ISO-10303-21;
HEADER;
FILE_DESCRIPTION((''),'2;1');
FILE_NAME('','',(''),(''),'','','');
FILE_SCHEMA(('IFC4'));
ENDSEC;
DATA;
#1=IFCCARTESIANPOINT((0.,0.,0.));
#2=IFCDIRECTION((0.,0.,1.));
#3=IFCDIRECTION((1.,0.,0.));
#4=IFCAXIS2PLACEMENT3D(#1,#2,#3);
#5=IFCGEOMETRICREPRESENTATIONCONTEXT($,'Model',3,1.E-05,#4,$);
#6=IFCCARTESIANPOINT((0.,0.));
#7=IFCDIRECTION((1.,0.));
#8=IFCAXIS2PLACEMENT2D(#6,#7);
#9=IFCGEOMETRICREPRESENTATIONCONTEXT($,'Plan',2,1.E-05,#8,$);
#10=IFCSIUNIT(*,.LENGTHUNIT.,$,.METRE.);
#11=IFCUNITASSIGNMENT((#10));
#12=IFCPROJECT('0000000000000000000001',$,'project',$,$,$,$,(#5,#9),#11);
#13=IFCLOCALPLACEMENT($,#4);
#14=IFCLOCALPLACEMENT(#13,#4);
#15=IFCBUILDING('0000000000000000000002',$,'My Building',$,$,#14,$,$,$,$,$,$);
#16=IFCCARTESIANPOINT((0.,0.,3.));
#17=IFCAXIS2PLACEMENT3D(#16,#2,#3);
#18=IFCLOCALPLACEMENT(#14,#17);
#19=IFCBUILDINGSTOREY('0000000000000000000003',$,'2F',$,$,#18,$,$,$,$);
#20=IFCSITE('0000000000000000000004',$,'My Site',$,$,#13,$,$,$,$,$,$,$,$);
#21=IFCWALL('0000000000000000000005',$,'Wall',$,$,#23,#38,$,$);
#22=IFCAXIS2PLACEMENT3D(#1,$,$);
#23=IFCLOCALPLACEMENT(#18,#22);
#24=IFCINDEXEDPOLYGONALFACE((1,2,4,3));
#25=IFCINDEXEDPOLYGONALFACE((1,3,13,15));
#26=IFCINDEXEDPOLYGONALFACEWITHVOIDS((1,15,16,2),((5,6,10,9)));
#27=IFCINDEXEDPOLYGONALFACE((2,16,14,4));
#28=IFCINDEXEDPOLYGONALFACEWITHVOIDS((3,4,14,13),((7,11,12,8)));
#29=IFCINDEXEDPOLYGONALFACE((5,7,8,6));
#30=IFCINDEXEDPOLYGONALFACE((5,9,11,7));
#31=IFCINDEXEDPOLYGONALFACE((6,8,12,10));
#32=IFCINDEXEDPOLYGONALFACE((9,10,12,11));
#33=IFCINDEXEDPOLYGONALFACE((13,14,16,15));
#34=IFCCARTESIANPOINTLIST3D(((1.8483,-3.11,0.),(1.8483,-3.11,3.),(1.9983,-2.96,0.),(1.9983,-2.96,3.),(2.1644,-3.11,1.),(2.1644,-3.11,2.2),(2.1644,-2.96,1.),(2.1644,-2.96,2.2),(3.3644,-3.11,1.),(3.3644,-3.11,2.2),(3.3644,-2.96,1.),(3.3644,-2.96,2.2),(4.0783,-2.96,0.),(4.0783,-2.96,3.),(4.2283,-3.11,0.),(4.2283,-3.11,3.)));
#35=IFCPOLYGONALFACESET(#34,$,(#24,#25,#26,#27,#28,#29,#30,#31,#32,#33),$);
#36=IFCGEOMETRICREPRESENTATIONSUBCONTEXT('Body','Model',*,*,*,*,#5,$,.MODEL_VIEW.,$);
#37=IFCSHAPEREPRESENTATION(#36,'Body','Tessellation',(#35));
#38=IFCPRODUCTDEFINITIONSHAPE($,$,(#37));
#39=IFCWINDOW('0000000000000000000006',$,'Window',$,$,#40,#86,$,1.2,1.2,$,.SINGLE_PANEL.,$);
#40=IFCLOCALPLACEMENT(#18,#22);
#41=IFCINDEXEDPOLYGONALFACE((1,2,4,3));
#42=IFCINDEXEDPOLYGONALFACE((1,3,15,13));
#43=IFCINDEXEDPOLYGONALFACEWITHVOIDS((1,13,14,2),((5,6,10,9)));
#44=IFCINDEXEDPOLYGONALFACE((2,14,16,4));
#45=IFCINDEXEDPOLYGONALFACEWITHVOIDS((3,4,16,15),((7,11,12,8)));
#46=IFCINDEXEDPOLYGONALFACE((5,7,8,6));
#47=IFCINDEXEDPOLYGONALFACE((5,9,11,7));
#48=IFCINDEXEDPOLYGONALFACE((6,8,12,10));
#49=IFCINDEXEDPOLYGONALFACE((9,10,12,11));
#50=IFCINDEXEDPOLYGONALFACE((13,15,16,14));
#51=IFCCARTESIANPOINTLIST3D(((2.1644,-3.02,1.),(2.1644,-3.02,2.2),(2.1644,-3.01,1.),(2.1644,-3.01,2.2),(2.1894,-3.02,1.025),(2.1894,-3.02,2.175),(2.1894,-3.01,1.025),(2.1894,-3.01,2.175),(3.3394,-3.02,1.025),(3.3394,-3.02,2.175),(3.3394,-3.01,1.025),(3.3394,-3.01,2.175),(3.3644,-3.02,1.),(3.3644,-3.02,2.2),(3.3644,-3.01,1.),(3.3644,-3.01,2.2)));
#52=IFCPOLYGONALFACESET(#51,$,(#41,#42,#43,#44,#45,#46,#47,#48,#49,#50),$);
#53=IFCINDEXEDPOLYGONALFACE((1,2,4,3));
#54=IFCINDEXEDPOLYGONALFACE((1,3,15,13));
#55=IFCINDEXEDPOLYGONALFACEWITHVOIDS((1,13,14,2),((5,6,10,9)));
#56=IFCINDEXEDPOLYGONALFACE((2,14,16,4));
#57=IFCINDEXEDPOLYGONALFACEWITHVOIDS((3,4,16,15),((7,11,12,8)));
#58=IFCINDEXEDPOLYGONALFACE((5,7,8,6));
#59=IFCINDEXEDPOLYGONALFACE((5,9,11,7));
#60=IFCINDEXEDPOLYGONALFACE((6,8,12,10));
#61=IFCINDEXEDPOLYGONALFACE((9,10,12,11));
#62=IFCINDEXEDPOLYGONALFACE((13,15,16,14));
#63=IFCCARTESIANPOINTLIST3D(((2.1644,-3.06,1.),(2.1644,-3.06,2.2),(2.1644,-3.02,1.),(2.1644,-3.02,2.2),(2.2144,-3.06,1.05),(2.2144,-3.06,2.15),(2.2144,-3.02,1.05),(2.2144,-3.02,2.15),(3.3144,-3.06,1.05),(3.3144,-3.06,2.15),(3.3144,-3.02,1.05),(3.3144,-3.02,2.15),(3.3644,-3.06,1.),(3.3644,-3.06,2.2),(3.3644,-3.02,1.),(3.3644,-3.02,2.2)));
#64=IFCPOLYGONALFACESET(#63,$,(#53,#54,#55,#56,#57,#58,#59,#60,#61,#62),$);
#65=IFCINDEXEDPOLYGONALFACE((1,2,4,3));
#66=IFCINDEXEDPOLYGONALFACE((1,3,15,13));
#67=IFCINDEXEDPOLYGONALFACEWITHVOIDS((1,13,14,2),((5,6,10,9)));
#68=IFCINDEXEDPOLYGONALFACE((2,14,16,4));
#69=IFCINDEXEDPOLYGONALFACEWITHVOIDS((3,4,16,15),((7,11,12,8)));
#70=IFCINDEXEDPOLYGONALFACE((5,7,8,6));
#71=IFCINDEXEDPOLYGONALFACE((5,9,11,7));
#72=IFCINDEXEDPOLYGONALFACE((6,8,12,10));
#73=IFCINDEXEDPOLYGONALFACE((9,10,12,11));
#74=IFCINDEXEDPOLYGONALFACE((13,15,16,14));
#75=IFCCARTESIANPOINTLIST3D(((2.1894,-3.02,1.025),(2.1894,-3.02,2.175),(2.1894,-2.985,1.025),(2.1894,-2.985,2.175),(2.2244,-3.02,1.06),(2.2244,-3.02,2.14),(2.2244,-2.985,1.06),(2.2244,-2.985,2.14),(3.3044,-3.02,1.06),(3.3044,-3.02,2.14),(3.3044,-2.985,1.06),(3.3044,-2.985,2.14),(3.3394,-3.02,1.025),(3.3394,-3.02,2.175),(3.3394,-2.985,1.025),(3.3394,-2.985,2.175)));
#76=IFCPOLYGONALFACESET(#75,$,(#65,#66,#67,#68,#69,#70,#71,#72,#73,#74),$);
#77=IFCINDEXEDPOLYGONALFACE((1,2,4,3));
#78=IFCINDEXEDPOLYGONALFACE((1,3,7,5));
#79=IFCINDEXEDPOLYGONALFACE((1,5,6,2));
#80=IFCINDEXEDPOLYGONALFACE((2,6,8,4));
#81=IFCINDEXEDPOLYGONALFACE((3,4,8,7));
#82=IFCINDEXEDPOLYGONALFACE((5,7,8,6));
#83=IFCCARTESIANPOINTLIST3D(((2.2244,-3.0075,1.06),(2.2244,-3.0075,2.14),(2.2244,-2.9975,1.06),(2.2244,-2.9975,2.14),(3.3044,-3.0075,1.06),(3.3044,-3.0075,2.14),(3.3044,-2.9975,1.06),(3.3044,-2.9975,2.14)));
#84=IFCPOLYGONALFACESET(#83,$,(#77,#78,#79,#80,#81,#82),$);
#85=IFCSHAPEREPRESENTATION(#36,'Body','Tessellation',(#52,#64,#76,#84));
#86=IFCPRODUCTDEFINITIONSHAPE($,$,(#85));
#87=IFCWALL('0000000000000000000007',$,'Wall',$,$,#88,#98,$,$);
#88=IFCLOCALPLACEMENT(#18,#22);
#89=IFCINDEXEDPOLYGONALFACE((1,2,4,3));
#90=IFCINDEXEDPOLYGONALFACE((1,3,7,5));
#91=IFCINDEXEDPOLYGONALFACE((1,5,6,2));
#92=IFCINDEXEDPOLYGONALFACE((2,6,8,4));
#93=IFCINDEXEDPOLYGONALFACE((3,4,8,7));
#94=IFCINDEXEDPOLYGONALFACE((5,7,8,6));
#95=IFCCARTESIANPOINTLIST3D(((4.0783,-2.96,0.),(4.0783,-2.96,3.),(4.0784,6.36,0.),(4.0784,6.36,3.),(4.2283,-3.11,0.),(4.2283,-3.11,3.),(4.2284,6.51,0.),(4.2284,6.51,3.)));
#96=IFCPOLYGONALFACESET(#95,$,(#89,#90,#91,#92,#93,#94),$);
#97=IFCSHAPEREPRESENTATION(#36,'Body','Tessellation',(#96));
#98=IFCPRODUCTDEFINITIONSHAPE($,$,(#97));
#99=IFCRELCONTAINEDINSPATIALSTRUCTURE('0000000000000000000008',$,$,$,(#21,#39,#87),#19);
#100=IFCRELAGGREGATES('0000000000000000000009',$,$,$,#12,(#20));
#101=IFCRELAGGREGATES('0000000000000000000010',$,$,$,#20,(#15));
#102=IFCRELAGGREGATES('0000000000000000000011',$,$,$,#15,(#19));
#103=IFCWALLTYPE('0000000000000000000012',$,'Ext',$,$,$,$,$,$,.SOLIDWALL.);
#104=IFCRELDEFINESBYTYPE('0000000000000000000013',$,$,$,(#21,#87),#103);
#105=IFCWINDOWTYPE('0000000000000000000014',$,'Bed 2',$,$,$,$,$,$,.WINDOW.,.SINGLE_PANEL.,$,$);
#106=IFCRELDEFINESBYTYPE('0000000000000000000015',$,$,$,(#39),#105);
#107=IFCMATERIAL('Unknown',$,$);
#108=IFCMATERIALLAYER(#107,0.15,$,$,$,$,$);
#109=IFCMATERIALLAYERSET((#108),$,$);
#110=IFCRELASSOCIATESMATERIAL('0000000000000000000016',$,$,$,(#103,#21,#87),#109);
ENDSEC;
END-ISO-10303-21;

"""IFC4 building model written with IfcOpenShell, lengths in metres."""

from ifc_helpers import new_model, entity, si_unit, frame, origin_with_axes, origin_2d_with_axis, place, context, subcontext, project, spatial, line, indexed_curve, outline, extrude, shape, source, transform, mapped, material, layer, layer_set, layer_usage, type_object, type_shapes, element, fill, save


model = new_model("IFC4")

# Units and contexts
model_context = context("Model", 3, precision=1e-05, world=origin_with_axes())
plan_context = context("Plan", 2, precision=1e-05, world=origin_2d_with_axis())
body_context_1 = subcontext(model_context, "Body", "Model", "MODEL_VIEW")
body_context_2 = subcontext(plan_context, "Body", "Plan", "PLAN_VIEW")
ifc_project = project(units=[si_unit("LENGTHUNIT", "METRE")], contexts=[model_context, plan_context])

# Site, building, storey
site_placement = place(None, origin_with_axes())
site = spatial("IfcSite", under=ifc_project, at=site_placement, Name="My Site")
building_placement = place(site_placement, origin_with_axes())
building = spatial("IfcBuilding", under=site, at=building_placement, Name="My Building")
storey_placement = place(building_placement, frame((0.0, 0.0, 3.0), z_axis=(0.0, 0.0, 1.0), x_axis=(1.0, 0.0, 0.0)))
storey = spatial("IfcBuildingStorey", under=building, at=storey_placement, Name="2F")

# Shared definitions
ifc_material = material(Name="Unknown")

# Shared definitions
ifc_layer_1 = layer(ifc_material, 0.15)
ifc_layer_set_1 = layer_set([ifc_layer_1])
wall_type_1 = type_object("IfcWallType", Name="Ext", PredefinedType="SOLIDWALL", material=ifc_layer_set_1)

# Wall, opening, window
ifc_layer_usage_1 = layer_usage(ifc_layer_set_1, "AXIS2", "POSITIVE", 0.0)
wall_1_placement = place(storey_placement, frame((1.8483, -3.11, 0.0), z_axis=(0.0, 0.0, 1.0), x_axis=(1.0, 0.0, 0.0)))
wall_1 = element("IfcWall", 1, at=wall_1_placement, inside=storey, type_object=wall_type_1, material=ifc_layer_usage_1, Name="Wall", context=body_context_1, shape_type="SweptSolid", body=[
    extrude(outline(indexed_curve([(0.0, 0.0), (0.15, 0.15), (2.23, 0.15), (2.38, 0.0)], segments=[line(1, 2, 3, 4, 1)])), origin_with_axes(), (0.0, 0.0, 1.0), 3.0),
])
shared_shape_1 = source(origin_with_axes(), body_context_1, "Body", "SweptSolid", [
    extrude(outline(indexed_curve([(0.0, 0.0), (1.2, 0.0), (1.2, 1.2), (0.0, 1.2)], segments=[line(1, 2, 3, 4, 1)])), frame((0.0, -0.6, 0.0), z_axis=(0.0, -1.0, 0.0), x_axis=(1.0, 0.0, 0.0)), (0.0, 0.0, -1.0), 1.2),
])
opening_1_placement = place(wall_1_placement, frame((0.316, 0.0, 1.0), z_axis=(0.0, 0.0, 1.0), x_axis=(1.0, 0.0, 0.0)))
opening_1 = element("IfcOpeningElement", 2, at=opening_1_placement, cuts=wall_1, PredefinedType="OPENING", context=body_context_1, shape_type="MappedRepresentation", body=[
    mapped(shared_shape_1, transform((0.0, 0.0, 0.0), x_axis=(1.0, 0.0, 0.0), y_axis=(0.0, 1.0, 0.0), z_axis=(0.0, 0.0, 1.0), scale=1.0)),
])
window_type = type_object("IfcWindowType", Name="Bed 2", PartitioningType="SINGLE_PANEL", PredefinedType="WINDOW")
shared_shape_2 = source(origin_with_axes(), body_context_1, "Body", "SweptSolid", [
    extrude(outline(indexed_curve([(0.0, 1.2), (1.2, 1.2), (1.2, 0.0), (0.0, 0.0), (0.0, 1.2)]), holes=[indexed_curve([(0.025, 1.175), (1.175, 1.175), (1.175, 0.025), (0.025, 0.025), (0.025, 1.175)])]), frame((0.0, 0.09, 0.0), z_axis=(0.0, -1.0, 0.0), x_axis=(1.0, 0.0, 0.0)), (0.0, 0.0, -1.0), 0.01),
    extrude(outline(indexed_curve([(0.0, 0.0), (1.2, 0.0), (1.2, 1.2), (0.0, 1.2)], segments=[line(1, 2, 3, 4, 1)]), holes=[indexed_curve([(0.05, 0.05), (1.15, 0.05), (1.15, 1.15), (0.05, 1.15)], segments=[line(1, 2, 3, 4, 1)])]), frame((0.0, 0.05, 0.0), z_axis=(0.0, -1.0, 0.0), x_axis=(1.0, 0.0, 0.0)), (0.0, 0.0, -1.0), 0.04),
    extrude(outline(indexed_curve([(0.0, 0.0), (1.15, 0.0), (1.15, 1.15), (0.0, 1.15)], segments=[line(1, 2, 3, 4, 1)]), holes=[indexed_curve([(0.035, 0.035), (1.115, 0.035), (1.115, 1.115), (0.035, 1.115)], segments=[line(1, 2, 3, 4, 1)])]), frame((0.025, 0.09, 0.025), z_axis=(0.0, -1.0, 0.0), x_axis=(1.0, 0.0, 0.0)), (0.0, 0.0, -1.0), 0.035),
    extrude(outline(indexed_curve([(0.035, 0.035), (1.115, 0.035), (1.115, 1.115), (0.035, 1.115)], segments=[line(1, 2, 3, 4, 1)])), frame((0.025, 0.1025, 0.025), z_axis=(0.0, -1.0, 0.0), x_axis=(1.0, 0.0, 0.0)), (0.0, 0.0, -1.0), 0.01),
])
shared_shape_3 = source(origin_with_axes(), body_context_2, "Body", "Curve2D", [
    entity("IfcIndexedPolyCurve", entity("IfcCartesianPointList2D", [[0.05, 0.05], [1.15, 0.05]])),
    entity("IfcIndexedPolyCurve", entity("IfcCartesianPointList2D", [[0.0, 0.1], [0.025, 0.1], [0.025, 0.09], [0.05, 0.09], [0.05, 0.05], [0.0, 0.05]]), [entity("IfcLineIndex", [1, 2, 3, 4, 5, 6, 1])]),
    entity("IfcIndexedPolyCurve", entity("IfcCartesianPointList2D", [[1.2, 0.1], [1.175, 0.1], [1.175, 0.09], [1.15, 0.09], [1.15, 0.05], [1.2, 0.05]]), [entity("IfcLineIndex", [1, 2, 3, 4, 5, 6, 1])]),
    entity("IfcIndexedPolyCurve", entity("IfcCartesianPointList2D", [[0.025, 0.09], [0.06, 0.09], [0.06, 0.125], [0.025, 0.125]]), [entity("IfcLineIndex", [1, 2, 3, 4, 1])]),
    entity("IfcIndexedPolyCurve", entity("IfcCartesianPointList2D", [[1.175, 0.09], [1.14, 0.09], [1.14, 0.125], [1.175, 0.125]]), [entity("IfcLineIndex", [1, 2, 3, 4, 1])]),
    entity("IfcIndexedPolyCurve", entity("IfcCartesianPointList2D", [[0.06, 0.09], [1.14, 0.09]])),
    entity("IfcIndexedPolyCurve", entity("IfcCartesianPointList2D", [[0.06, 0.125], [1.14, 0.125]])),
    entity("IfcIndexedPolyCurve", entity("IfcCartesianPointList2D", [[0.06, 0.1075], [1.14, 0.1075]])),
])
type_shapes(window_type, [shared_shape_2, shared_shape_3])
window_placement = place(opening_1_placement, frame((0.0, 0.0, 0.0), z_axis=(0.0, 0.0, 1.0), x_axis=(1.0, 0.0, 0.0)))
window = element("IfcWindow", 3, at=window_placement, inside=storey, type_object=window_type, Name="Window", OverallHeight=1.2, OverallWidth=1.2, PartitioningType="SINGLE_PANEL", shapes=[
    shape(body_context_1, "Body", "MappedRepresentation", [mapped(shared_shape_2, transform((0.0, 0.0, 0.0), x_axis=(1.0, 0.0, 0.0), y_axis=(0.0, 1.0, 0.0), z_axis=(0.0, 0.0, 1.0), scale=1.0))]),
    shape(body_context_2, "Body", "MappedRepresentation", [mapped(shared_shape_3, transform((0.0, 0.0, 0.0), x_axis=(1.0, 0.0, 0.0), y_axis=(0.0, 1.0, 0.0), z_axis=(0.0, 0.0, 1.0), scale=1.0))]),
])
fill(opening_1, window)

# Wall
ifc_layer_usage_2 = layer_usage(ifc_layer_set_1, "AXIS2", "POSITIVE", 0.0)
wall_2_placement = place(storey_placement, frame((4.2283, -3.11, 0.0), z_axis=(0.0, 0.0, 1.0), x_axis=(0.0, 1.0, 0.0)))
element("IfcWall", 4, at=wall_2_placement, inside=storey, type_object=wall_type_1, material=ifc_layer_usage_2, Name="Wall", context=body_context_1, shape_type="SweptSolid", body=[
    extrude(outline(indexed_curve([(0.0, 0.0), (0.15, 0.15), (9.47, 0.15), (9.62, 0.0)], segments=[line(1, 2, 3, 4, 1)])), origin_with_axes(), (0.0, 0.0, 1.0), 3.0),
])

save(model, "model.ifc")
